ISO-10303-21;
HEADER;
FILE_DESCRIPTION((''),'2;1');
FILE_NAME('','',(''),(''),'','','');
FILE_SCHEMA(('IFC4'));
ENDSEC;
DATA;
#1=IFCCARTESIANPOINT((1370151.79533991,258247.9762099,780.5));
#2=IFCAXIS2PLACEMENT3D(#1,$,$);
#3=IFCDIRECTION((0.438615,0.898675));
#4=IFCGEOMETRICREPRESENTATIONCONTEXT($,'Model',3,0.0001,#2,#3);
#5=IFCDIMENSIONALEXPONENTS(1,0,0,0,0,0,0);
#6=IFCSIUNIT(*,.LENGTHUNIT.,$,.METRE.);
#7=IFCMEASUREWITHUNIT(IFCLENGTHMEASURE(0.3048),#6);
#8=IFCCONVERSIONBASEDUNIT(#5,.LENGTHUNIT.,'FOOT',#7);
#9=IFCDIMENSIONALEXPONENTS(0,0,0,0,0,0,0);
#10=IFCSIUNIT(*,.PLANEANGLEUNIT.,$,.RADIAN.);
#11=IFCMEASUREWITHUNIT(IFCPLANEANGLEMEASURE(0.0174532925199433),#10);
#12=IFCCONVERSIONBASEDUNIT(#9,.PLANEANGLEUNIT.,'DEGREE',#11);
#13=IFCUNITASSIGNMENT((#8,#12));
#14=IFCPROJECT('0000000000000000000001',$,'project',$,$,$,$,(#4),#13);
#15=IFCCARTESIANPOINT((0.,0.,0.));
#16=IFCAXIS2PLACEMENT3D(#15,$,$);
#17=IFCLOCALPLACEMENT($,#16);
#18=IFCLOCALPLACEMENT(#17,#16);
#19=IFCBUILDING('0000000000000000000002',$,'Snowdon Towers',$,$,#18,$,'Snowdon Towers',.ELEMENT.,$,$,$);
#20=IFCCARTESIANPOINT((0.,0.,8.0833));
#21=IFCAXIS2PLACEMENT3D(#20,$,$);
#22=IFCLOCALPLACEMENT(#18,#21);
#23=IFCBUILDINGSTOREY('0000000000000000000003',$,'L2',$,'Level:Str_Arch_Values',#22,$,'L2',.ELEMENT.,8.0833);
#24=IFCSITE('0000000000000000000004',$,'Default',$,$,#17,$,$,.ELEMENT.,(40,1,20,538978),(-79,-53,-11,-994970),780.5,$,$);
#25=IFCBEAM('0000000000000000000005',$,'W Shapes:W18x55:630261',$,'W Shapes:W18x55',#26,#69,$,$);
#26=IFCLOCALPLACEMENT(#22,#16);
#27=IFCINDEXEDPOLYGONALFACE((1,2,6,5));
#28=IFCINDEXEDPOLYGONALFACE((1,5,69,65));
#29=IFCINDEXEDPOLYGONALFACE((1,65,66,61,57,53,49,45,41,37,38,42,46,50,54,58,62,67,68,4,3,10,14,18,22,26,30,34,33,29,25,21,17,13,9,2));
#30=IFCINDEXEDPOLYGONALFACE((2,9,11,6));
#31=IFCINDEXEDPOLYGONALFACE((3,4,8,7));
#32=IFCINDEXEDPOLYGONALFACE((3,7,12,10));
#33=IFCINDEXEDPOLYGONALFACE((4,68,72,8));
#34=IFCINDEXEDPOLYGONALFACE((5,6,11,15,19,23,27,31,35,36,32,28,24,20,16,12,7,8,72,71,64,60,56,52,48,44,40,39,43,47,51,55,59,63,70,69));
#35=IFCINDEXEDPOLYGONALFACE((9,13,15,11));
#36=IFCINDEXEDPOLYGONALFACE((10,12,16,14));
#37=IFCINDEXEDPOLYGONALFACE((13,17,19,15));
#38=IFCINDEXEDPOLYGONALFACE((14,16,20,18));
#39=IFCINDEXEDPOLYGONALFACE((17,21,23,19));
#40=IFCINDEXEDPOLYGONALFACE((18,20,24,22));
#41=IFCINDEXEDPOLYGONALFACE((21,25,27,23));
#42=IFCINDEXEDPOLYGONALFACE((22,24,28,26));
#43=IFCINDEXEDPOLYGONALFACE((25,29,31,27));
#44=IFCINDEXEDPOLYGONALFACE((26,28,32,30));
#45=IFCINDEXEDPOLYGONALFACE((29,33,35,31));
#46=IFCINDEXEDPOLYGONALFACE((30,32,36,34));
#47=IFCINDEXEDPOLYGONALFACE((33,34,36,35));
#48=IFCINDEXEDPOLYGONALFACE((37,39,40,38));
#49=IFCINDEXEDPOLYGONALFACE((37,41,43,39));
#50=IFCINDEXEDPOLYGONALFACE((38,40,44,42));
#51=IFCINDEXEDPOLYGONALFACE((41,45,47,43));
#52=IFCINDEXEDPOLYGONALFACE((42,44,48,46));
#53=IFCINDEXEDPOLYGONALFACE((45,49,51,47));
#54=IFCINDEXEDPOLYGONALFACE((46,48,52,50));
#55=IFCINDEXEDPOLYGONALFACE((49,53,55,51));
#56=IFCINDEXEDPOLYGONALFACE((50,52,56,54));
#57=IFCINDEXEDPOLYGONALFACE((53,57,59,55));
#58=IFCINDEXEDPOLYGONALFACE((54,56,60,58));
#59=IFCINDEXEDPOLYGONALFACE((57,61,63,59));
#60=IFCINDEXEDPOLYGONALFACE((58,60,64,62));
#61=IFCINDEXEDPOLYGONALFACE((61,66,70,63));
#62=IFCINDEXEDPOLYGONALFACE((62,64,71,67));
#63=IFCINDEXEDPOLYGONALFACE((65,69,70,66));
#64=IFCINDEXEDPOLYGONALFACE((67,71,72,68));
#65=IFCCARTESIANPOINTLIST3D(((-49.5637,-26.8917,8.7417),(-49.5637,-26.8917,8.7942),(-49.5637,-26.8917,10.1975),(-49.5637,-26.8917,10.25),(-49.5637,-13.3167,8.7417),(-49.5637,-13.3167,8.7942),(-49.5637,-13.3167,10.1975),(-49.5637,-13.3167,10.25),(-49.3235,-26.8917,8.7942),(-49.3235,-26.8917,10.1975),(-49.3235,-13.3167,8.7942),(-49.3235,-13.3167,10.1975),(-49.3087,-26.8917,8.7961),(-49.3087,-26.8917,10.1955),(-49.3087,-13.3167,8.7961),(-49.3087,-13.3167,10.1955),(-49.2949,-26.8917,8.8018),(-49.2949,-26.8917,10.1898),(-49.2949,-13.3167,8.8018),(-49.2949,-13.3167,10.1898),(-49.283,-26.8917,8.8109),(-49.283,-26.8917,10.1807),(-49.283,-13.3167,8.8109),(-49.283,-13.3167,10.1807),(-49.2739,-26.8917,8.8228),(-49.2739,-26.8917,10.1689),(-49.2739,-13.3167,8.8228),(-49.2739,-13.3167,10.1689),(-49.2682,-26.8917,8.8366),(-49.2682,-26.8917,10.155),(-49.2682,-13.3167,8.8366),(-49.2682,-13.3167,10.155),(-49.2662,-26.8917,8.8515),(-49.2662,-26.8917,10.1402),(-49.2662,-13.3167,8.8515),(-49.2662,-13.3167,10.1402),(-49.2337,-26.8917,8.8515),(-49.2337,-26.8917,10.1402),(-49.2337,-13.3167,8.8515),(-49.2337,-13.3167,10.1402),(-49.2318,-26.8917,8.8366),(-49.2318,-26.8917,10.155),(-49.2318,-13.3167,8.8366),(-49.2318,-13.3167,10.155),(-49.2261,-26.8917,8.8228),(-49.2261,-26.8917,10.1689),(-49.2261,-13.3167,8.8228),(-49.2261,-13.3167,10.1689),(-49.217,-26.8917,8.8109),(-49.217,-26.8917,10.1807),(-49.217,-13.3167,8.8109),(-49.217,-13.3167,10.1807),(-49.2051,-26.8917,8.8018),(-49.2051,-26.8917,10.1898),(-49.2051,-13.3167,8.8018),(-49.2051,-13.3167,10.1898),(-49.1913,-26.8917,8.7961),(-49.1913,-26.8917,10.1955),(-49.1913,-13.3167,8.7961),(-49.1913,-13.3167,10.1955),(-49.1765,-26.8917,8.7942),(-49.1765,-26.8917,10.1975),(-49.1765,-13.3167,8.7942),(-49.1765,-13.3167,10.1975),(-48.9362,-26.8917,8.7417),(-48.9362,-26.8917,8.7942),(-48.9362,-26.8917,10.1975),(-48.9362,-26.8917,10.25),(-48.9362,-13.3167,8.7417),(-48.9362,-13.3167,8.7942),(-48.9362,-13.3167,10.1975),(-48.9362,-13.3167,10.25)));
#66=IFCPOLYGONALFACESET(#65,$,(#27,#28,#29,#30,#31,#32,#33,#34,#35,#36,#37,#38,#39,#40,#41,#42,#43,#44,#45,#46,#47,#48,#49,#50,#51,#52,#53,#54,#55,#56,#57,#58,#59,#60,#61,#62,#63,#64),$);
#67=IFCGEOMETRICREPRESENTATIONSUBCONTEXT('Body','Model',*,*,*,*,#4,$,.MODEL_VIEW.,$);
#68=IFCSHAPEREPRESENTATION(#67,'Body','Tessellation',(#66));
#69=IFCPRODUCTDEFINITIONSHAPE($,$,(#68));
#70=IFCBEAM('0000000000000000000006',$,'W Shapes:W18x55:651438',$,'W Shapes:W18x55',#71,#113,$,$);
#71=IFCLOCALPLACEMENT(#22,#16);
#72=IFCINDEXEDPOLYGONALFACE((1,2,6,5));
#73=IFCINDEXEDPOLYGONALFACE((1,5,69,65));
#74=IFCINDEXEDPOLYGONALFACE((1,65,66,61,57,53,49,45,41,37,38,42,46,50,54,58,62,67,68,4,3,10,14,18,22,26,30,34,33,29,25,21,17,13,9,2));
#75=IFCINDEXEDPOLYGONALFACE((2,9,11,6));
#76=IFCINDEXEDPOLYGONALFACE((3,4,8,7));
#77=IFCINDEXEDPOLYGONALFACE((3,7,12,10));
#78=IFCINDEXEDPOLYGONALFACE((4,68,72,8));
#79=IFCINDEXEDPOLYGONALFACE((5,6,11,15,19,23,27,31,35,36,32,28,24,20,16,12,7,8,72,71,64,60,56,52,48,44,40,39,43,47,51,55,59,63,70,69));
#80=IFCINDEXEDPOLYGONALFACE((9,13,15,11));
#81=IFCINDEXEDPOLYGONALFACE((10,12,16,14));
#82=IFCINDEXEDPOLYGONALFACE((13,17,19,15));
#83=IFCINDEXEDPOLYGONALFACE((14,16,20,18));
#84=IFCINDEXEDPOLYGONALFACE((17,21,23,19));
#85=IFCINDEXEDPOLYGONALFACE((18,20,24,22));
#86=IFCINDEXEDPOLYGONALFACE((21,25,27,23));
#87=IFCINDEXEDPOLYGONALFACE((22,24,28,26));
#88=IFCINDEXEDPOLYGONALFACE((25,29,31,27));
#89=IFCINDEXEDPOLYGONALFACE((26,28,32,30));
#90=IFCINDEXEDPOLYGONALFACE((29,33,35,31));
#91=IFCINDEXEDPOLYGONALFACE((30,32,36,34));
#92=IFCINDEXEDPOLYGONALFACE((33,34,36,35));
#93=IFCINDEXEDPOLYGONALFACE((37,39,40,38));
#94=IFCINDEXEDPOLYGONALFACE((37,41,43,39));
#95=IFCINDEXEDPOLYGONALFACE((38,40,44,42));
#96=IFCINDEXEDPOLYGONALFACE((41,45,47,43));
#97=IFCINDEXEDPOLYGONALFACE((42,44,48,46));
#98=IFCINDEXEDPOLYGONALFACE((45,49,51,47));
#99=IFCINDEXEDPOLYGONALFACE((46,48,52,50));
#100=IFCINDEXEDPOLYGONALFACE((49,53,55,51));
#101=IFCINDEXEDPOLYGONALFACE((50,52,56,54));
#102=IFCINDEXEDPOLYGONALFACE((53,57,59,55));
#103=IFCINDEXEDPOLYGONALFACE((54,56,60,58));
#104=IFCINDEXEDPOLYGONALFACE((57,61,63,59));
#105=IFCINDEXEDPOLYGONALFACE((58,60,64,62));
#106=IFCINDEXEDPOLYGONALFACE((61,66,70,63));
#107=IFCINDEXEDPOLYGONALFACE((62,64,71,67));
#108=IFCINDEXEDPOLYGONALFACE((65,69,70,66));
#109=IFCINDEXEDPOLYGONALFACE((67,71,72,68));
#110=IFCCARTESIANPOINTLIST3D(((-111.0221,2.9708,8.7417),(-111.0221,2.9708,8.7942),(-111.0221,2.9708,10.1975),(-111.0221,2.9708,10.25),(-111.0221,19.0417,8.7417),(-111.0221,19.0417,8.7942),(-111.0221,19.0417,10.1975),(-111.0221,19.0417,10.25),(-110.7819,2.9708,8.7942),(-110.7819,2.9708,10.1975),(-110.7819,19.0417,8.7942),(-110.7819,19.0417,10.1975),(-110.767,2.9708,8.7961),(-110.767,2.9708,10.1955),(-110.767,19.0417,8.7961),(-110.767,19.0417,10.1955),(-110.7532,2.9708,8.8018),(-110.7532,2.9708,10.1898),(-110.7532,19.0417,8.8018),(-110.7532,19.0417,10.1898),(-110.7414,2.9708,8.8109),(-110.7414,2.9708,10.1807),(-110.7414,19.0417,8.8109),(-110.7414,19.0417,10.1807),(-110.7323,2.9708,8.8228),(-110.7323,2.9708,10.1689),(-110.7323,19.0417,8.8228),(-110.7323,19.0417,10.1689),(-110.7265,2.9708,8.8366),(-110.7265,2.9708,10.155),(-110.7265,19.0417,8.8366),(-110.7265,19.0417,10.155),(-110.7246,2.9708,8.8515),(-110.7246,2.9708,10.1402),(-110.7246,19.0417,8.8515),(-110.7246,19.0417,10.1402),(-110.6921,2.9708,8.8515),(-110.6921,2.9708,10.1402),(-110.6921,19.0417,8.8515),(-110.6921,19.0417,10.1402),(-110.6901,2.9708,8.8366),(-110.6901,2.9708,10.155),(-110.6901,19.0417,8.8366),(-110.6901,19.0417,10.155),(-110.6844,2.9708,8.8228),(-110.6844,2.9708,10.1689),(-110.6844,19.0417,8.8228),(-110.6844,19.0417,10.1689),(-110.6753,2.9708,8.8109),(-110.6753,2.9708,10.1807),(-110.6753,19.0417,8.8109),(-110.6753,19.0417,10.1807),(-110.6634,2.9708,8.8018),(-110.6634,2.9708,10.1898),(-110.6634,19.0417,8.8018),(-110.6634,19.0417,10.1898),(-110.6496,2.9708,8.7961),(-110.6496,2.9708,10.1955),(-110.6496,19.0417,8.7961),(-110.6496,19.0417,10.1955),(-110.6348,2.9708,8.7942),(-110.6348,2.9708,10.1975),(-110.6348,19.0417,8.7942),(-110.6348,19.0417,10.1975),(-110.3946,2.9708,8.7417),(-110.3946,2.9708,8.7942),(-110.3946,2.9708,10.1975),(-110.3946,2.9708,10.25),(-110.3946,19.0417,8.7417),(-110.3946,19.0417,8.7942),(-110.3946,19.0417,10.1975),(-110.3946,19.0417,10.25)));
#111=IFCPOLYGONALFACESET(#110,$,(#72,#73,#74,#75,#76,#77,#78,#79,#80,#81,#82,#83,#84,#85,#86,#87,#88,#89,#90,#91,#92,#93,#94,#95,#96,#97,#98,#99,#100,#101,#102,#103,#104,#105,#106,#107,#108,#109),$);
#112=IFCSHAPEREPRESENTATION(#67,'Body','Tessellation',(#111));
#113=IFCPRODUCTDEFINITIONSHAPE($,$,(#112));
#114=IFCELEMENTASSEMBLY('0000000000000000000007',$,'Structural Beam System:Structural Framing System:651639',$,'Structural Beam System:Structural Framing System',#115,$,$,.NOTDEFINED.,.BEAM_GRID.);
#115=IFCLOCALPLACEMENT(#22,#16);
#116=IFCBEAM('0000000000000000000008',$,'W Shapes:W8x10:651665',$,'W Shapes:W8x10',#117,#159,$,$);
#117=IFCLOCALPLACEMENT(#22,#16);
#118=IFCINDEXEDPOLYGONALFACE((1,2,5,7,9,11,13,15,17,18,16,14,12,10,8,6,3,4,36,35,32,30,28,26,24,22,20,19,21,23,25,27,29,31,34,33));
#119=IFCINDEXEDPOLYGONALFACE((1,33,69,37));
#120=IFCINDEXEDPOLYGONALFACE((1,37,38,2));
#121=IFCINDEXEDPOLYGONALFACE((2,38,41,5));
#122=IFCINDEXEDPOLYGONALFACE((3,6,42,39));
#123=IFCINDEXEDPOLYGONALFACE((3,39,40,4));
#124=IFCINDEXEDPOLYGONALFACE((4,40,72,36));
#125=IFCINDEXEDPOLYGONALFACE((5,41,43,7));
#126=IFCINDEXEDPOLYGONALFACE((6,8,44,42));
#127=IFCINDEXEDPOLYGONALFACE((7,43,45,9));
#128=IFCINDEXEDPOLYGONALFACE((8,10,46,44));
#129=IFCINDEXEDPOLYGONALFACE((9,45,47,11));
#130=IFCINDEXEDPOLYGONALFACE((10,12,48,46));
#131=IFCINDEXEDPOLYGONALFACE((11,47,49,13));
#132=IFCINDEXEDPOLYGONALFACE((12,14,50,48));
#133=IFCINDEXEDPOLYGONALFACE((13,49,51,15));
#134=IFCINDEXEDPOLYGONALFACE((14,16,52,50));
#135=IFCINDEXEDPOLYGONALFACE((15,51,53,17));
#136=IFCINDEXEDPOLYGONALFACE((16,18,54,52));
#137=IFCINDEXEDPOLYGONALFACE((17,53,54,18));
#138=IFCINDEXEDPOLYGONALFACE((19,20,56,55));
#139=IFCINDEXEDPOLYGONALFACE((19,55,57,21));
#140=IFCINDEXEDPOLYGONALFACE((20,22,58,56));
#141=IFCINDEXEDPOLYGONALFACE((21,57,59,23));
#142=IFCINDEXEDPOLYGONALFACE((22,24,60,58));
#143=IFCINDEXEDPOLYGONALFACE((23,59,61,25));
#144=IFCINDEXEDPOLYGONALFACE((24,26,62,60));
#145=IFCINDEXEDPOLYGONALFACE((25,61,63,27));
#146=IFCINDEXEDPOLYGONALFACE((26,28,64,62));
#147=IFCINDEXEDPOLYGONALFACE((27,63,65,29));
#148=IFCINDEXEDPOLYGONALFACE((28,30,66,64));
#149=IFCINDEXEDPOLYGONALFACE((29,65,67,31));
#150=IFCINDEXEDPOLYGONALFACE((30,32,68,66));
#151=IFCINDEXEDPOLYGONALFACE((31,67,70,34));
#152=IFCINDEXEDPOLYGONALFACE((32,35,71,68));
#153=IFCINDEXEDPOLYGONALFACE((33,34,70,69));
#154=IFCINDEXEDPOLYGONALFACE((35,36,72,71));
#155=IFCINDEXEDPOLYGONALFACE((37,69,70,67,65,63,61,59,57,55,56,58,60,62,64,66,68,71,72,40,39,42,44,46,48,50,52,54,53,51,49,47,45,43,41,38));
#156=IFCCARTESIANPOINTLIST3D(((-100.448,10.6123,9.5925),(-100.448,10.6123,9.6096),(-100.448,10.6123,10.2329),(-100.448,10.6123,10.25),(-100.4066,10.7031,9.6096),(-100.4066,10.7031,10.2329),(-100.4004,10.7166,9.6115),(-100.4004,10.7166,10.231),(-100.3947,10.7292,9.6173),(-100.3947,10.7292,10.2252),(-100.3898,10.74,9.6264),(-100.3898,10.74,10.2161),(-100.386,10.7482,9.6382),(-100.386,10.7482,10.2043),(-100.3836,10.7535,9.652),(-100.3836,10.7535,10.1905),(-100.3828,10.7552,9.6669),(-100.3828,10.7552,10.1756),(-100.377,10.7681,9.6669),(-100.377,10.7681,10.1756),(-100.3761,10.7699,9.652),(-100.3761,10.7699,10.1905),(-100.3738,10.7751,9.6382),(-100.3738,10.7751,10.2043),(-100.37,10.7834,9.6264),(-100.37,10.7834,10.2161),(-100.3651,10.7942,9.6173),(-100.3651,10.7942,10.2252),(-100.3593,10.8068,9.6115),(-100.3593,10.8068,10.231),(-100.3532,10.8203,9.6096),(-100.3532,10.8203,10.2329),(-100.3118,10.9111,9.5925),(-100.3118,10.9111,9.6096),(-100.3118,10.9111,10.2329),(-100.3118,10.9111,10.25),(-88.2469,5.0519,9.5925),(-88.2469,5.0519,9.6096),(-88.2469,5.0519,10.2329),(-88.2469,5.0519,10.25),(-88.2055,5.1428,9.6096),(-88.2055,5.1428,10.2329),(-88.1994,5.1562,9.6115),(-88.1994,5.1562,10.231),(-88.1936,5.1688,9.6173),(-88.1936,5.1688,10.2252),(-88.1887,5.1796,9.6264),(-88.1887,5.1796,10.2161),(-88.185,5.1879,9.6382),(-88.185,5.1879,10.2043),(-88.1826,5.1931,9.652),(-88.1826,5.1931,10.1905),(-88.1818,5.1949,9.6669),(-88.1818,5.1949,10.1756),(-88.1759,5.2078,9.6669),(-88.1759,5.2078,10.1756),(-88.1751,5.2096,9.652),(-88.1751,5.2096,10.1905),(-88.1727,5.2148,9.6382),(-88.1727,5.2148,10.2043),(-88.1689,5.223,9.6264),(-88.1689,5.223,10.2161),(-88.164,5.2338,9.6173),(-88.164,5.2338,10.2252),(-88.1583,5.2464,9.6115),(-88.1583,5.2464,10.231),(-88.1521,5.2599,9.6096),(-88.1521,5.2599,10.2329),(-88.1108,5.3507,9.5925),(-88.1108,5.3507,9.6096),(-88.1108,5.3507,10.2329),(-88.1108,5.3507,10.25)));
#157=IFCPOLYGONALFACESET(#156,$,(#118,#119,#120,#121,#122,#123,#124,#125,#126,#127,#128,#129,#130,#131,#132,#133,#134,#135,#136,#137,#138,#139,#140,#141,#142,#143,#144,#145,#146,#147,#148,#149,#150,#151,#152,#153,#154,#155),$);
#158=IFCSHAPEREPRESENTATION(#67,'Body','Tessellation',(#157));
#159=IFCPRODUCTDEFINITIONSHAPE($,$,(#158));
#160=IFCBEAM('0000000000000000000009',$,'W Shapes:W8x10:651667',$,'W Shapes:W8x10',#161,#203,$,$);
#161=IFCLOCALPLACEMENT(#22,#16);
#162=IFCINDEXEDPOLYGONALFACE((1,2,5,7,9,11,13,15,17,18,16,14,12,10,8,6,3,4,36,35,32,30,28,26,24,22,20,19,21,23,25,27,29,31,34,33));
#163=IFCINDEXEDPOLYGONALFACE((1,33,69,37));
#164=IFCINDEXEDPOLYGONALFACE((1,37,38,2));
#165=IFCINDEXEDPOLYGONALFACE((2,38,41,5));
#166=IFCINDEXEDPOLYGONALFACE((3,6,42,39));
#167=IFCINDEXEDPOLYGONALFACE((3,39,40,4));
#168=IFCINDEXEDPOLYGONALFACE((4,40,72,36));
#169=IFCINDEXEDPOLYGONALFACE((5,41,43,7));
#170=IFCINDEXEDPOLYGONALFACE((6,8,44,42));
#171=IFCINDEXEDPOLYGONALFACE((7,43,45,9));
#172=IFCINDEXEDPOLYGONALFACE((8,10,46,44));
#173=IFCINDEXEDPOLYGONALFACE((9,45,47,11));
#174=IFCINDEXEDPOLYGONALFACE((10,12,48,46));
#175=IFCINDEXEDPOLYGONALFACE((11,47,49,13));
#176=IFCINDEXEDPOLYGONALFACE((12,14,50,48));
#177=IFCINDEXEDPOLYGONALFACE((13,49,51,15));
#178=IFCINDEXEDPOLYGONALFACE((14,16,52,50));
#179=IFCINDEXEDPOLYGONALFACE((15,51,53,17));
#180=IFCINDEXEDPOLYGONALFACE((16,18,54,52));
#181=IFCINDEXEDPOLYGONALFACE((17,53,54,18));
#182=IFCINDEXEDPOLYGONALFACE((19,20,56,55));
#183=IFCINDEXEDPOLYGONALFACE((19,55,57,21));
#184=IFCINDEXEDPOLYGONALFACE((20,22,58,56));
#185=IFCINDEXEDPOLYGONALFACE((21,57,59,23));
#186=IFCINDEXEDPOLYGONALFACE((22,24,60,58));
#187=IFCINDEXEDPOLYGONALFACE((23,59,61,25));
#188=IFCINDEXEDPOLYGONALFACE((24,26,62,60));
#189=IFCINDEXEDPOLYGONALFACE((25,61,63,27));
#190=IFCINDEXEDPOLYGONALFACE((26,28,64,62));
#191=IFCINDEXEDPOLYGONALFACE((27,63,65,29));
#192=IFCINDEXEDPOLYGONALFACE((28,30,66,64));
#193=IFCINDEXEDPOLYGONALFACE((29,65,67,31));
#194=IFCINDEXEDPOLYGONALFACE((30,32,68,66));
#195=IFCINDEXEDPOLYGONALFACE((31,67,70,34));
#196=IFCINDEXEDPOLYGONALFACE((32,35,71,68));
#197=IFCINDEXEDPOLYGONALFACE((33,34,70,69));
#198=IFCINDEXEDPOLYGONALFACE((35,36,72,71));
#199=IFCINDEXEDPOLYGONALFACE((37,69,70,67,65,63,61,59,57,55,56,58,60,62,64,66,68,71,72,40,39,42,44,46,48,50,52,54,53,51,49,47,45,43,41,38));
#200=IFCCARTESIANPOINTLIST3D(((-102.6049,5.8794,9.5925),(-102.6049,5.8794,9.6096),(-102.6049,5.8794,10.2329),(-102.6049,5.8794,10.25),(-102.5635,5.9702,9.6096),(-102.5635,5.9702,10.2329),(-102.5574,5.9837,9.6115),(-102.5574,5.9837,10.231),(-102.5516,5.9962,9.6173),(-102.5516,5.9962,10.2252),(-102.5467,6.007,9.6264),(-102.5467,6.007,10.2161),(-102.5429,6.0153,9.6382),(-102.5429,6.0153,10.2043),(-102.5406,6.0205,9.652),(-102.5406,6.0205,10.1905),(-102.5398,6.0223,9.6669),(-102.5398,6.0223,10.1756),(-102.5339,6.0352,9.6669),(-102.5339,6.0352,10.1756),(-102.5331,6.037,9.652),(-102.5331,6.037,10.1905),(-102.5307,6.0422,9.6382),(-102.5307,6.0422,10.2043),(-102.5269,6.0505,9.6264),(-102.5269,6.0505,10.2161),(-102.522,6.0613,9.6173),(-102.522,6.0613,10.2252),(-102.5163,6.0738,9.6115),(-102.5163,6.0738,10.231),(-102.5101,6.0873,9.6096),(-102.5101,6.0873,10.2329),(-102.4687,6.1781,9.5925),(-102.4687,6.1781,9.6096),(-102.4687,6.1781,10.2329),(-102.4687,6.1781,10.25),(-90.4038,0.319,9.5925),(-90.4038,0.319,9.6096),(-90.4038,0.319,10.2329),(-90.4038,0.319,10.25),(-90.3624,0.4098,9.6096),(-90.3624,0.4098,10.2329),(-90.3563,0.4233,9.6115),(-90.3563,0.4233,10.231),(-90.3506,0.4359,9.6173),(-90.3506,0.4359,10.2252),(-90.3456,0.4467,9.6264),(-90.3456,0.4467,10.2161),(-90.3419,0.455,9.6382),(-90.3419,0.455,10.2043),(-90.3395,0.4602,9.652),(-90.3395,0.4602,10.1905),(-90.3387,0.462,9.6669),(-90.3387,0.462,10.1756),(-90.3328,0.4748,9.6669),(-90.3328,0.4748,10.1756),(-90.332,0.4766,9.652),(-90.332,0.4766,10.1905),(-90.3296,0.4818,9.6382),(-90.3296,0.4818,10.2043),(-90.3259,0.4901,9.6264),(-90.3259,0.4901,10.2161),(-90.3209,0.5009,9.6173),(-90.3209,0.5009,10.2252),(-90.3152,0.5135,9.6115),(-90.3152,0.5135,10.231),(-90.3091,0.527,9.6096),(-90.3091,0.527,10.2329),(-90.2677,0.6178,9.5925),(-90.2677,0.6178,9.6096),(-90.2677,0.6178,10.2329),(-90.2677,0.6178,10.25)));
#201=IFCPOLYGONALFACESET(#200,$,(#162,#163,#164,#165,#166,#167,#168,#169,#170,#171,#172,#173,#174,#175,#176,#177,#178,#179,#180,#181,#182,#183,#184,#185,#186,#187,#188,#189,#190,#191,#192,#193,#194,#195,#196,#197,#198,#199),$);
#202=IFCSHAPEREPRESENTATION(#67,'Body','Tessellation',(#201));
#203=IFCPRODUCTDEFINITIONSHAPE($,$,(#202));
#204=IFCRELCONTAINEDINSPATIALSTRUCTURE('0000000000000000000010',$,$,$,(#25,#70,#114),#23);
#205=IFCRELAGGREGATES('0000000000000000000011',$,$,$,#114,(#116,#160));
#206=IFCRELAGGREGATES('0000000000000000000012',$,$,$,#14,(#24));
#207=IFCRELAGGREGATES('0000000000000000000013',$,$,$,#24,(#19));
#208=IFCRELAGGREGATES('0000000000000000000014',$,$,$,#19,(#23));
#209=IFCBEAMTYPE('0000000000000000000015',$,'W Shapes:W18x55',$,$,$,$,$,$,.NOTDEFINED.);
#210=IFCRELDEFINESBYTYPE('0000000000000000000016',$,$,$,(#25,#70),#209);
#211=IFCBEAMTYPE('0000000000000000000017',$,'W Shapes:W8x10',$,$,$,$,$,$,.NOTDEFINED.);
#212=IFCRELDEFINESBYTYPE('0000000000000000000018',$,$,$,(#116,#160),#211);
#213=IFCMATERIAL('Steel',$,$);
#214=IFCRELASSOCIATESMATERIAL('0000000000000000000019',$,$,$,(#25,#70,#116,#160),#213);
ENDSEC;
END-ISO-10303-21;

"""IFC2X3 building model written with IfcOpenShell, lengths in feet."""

from ifc_helpers import new_model, entity, si_unit, converted_unit, direction, frame, frame_2d, origin, place, context, subcontext, project, spatial, i_section, extrude, material, type_object, element, aggregate, save


model = new_model("IFC2X3")

# Units and contexts
model_context = context("Model", 3, precision=0.0001, world=frame((1370151.79533991, 258247.9762099, 780.5)), true_north=direction((0.438615, 0.898675)))
body_context = subcontext(model_context, "Body", "Model", "MODEL_VIEW")
ifc_project = project(units=[converted_unit("LENGTHUNIT", "FOOT", entity("IfcLengthMeasure", 0.3048), si_unit("LENGTHUNIT", "METRE"), dimensions=[1, 0, 0, 0, 0, 0, 0]), converted_unit("PLANEANGLEUNIT", "DEGREE", entity("IfcPlaneAngleMeasure", 0.0174532925199433), si_unit("PLANEANGLEUNIT", "RADIAN"), dimensions=[0, 0, 0, 0, 0, 0, 0])], contexts=[model_context])

# Site, building, storey
site_placement = place(None, origin())
site = spatial("IfcSite", under=ifc_project, at=site_placement, Name="Default", CompositionType="ELEMENT", RefLatitude=(40, 1, 20, 538978), RefLongitude=(-79, -53, -11, -994970), RefElevation=780.5)
building_placement = place(site_placement, origin())
building = spatial("IfcBuilding", under=site, at=building_placement, Name="Snowdon Towers", LongName="Snowdon Towers", CompositionType="ELEMENT")
storey_placement = place(building_placement, frame((0.0, 0.0, 8.0833)))
storey = spatial("IfcBuildingStorey", under=building, at=storey_placement, Name="L2", ObjectType="Level:Str_Arch_Values", LongName="L2", CompositionType="ELEMENT", Elevation=8.0833)

# Beams
ifc_material_1 = material(Name="Steel")
beam_type_1 = type_object("IfcBeamType", Name="W Shapes:W18x55", PredefinedType="NOTDEFINED")
beam_1_placement = place(storey_placement, frame((-49.25, -12.7083, 10.25), z_axis=(0.0, 0.0, 1.0), x_axis=(0.0, -1.0, 0.0)))
element("IfcBeam", 1, at=beam_1_placement, inside=storey, type_object=beam_type_1, material=ifc_material_1, Name="W Shapes:W18x55:630261", ObjectType="W Shapes:W18x55", context=body_context, shape_type="SweptSolid", body=[
    extrude(i_section(OverallWidth=0.6275, OverallDepth=1.5083, WebThickness=0.0325, FlangeThickness=0.0525, FilletRadius=0.0573, at=frame_2d((0.0, 0.0), x_axis=(0.0, 1.0))), frame((0.6083, 0.0, -0.7542), z_axis=(1.0, 0.0, 0.0), x_axis=(0.0, 0.0, -1.0)), (0.0, 0.0, 1.0), 13.575),
])
beam_2_placement = place(storey_placement, frame((-110.7083, 2.5, 10.25), z_axis=(0.0, 0.0, 1.0), x_axis=(0.0, 1.0, 0.0)))
element("IfcBeam", 2, at=beam_2_placement, inside=storey, type_object=beam_type_1, material=ifc_material_1, Name="W Shapes:W18x55:651438", ObjectType="W Shapes:W18x55", context=body_context, shape_type="SweptSolid", body=[
    extrude(i_section(OverallWidth=0.6275, OverallDepth=1.5083, WebThickness=0.0325, FlangeThickness=0.0525, FilletRadius=0.0573, at=frame_2d((0.0, 0.0), x_axis=(0.0, 1.0))), frame((0.4708, 0.0, -0.7542), z_axis=(1.0, 0.0, 0.0), x_axis=(0.0, 0.0, -1.0)), (0.0, 0.0, 1.0), 16.0708),
])

# Element assembly, beams
assembly_1_placement = place(storey_placement, origin())
assembly_1 = element("IfcElementAssembly", 3, at=assembly_1_placement, inside=storey, Name="Structural Beam System:Structural Framing System:651639", ObjectType="Structural Beam System:Structural Framing System", AssemblyPlace="NOTDEFINED", PredefinedType="BEAM_GRID")
beam_type_2 = type_object("IfcBeamType", Name="W Shapes:W8x10", PredefinedType="NOTDEFINED")
beam_3_placement = place(assembly_1_placement, frame((-100.8008, 10.9535, 10.25), z_axis=(0.0, 0.0, 1.0), x_axis=(0.909961, -0.414693, 0.0)))
beam_3 = element("IfcBeam", 4, at=beam_3_placement, type_object=beam_type_2, material=ifc_material_1, Name="W Shapes:W8x10:651665", ObjectType="W Shapes:W8x10", context=body_context, shape_type="SweptSolid", body=[
    extrude(i_section(OverallWidth=0.3283, OverallDepth=0.6575, WebThickness=0.0142, FlangeThickness=0.0171, FilletRadius=0.0573, at=frame_2d((0.0, 0.0), x_axis=(0.0, 1.0))), frame((0.4625, 0.0, -0.3288), z_axis=(1.0, 0.0, 0.0), x_axis=(0.0, 0.0, -1.0)), (0.0, 0.0, 1.0), 13.4083),
])
beam_4_placement = place(assembly_1_placement, frame((-102.9577, 6.2205, 10.25), z_axis=(0.0, 0.0, 1.0), x_axis=(0.909961, -0.414693, 0.0)))
beam_4 = element("IfcBeam", 5, at=beam_4_placement, type_object=beam_type_2, material=ifc_material_1, Name="W Shapes:W8x10:651667", ObjectType="W Shapes:W8x10", context=body_context, shape_type="SweptSolid", body=[
    extrude(i_section(OverallWidth=0.3283, OverallDepth=0.6575, WebThickness=0.0142, FlangeThickness=0.0171, FilletRadius=0.0573, at=frame_2d((0.0, 0.0), x_axis=(0.0, 1.0))), frame((0.4625, 0.0, -0.3288), z_axis=(1.0, 0.0, 0.0), x_axis=(0.0, 0.0, -1.0)), (0.0, 0.0, 1.0), 13.4083),
])
aggregate(assembly_1, [beam_3, beam_4])

save(model, "model.ifc")
